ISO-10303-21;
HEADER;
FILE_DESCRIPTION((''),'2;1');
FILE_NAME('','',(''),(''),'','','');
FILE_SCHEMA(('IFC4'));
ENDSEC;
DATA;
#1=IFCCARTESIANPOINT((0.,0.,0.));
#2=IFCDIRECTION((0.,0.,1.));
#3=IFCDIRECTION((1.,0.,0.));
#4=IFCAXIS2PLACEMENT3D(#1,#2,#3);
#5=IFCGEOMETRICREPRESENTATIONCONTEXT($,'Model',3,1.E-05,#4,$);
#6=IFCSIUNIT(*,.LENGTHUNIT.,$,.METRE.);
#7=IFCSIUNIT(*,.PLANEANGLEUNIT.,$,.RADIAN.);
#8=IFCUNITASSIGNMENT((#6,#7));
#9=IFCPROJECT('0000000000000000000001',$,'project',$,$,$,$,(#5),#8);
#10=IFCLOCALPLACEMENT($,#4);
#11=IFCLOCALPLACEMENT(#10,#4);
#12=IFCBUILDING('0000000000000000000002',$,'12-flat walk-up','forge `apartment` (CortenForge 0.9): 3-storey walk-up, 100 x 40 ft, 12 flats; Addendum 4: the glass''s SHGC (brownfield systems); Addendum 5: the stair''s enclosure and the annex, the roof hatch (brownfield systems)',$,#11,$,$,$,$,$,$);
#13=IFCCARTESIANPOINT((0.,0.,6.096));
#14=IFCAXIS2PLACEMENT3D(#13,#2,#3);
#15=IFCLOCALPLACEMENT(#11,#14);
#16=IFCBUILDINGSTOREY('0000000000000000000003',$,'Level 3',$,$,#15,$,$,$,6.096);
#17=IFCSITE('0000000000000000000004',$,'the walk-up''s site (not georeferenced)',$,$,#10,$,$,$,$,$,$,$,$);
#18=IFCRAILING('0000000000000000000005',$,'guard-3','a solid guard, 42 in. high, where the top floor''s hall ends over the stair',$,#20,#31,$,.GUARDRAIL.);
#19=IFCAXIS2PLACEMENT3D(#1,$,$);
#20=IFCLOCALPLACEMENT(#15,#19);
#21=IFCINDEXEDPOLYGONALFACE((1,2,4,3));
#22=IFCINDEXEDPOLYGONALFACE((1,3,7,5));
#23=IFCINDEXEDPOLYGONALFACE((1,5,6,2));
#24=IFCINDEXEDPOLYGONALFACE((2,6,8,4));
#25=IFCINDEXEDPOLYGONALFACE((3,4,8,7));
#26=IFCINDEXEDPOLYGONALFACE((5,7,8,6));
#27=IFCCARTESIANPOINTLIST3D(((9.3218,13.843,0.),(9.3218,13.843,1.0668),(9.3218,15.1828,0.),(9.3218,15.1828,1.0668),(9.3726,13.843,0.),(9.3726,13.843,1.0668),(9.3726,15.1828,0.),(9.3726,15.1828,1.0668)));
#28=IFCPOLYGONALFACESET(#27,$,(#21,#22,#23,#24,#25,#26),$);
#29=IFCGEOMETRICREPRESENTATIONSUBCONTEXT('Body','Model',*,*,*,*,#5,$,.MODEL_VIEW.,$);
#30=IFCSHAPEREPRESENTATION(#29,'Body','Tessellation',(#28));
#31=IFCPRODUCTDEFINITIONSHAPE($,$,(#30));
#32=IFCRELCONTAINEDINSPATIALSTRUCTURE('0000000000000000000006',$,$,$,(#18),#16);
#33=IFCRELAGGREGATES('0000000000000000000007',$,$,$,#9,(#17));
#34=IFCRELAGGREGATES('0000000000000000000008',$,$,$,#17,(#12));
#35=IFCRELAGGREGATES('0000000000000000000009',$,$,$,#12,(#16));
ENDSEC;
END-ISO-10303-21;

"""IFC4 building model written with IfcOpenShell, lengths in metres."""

from ifc_helpers import new_model, si_unit, frame, frame_2d, origin, origin_with_axes, place, context, subcontext, project, spatial, rectangle, extrude, element, save


model = new_model("IFC4")

# Units and contexts
model_context = context("Model", 3, precision=1e-05, world=origin_with_axes())
body_context = subcontext(model_context, "Body", "Model", "MODEL_VIEW")
ifc_project = project(units=[si_unit("LENGTHUNIT", "METRE"), si_unit("PLANEANGLEUNIT", "RADIAN")], contexts=[model_context])

# Site, building, storey
site_placement = place(None, origin_with_axes())
site = spatial("IfcSite", under=ifc_project, at=site_placement, Name="the walk-up's site (not georeferenced)")
building_placement = place(site_placement, origin_with_axes())
building = spatial("IfcBuilding", under=site, at=building_placement, Name="12-flat walk-up", Description="forge `apartment` (CortenForge 0.9): 3-storey walk-up, 100 x 40 ft, 12 flats; Addendum 4: the glass's SHGC (brownfield systems); Addendum 5: the stair's enclosure and the annex, the roof hatch (brownfield systems)")
storey_placement = place(building_placement, frame((0.0, 0.0, 6.096), z_axis=(0.0, 0.0, 1.0), x_axis=(1.0, 0.0, 0.0)))
storey = spatial("IfcBuildingStorey", under=building, at=storey_placement, Name="Level 3", Elevation=6.096)

# Railing
railing_placement = place(storey_placement, frame((9.3218, 13.843, 0.0), z_axis=(0.0, 0.0, 1.0), x_axis=(1.0, 0.0, 0.0)))
element("IfcRailing", 1, at=railing_placement, inside=storey, Name="guard-3", Description="a solid guard, 42 in. high, where the top floor's hall ends over the stair", PredefinedType="GUARDRAIL", context=body_context, shape_type="SweptSolid", body=[
    extrude(rectangle(XDim=0.0508, YDim=1.3399, at=frame_2d((0.0254, 0.6699))), origin(), (0.0, 0.0, 1.0), 1.0668),
])

save(model, "model.ifc")
